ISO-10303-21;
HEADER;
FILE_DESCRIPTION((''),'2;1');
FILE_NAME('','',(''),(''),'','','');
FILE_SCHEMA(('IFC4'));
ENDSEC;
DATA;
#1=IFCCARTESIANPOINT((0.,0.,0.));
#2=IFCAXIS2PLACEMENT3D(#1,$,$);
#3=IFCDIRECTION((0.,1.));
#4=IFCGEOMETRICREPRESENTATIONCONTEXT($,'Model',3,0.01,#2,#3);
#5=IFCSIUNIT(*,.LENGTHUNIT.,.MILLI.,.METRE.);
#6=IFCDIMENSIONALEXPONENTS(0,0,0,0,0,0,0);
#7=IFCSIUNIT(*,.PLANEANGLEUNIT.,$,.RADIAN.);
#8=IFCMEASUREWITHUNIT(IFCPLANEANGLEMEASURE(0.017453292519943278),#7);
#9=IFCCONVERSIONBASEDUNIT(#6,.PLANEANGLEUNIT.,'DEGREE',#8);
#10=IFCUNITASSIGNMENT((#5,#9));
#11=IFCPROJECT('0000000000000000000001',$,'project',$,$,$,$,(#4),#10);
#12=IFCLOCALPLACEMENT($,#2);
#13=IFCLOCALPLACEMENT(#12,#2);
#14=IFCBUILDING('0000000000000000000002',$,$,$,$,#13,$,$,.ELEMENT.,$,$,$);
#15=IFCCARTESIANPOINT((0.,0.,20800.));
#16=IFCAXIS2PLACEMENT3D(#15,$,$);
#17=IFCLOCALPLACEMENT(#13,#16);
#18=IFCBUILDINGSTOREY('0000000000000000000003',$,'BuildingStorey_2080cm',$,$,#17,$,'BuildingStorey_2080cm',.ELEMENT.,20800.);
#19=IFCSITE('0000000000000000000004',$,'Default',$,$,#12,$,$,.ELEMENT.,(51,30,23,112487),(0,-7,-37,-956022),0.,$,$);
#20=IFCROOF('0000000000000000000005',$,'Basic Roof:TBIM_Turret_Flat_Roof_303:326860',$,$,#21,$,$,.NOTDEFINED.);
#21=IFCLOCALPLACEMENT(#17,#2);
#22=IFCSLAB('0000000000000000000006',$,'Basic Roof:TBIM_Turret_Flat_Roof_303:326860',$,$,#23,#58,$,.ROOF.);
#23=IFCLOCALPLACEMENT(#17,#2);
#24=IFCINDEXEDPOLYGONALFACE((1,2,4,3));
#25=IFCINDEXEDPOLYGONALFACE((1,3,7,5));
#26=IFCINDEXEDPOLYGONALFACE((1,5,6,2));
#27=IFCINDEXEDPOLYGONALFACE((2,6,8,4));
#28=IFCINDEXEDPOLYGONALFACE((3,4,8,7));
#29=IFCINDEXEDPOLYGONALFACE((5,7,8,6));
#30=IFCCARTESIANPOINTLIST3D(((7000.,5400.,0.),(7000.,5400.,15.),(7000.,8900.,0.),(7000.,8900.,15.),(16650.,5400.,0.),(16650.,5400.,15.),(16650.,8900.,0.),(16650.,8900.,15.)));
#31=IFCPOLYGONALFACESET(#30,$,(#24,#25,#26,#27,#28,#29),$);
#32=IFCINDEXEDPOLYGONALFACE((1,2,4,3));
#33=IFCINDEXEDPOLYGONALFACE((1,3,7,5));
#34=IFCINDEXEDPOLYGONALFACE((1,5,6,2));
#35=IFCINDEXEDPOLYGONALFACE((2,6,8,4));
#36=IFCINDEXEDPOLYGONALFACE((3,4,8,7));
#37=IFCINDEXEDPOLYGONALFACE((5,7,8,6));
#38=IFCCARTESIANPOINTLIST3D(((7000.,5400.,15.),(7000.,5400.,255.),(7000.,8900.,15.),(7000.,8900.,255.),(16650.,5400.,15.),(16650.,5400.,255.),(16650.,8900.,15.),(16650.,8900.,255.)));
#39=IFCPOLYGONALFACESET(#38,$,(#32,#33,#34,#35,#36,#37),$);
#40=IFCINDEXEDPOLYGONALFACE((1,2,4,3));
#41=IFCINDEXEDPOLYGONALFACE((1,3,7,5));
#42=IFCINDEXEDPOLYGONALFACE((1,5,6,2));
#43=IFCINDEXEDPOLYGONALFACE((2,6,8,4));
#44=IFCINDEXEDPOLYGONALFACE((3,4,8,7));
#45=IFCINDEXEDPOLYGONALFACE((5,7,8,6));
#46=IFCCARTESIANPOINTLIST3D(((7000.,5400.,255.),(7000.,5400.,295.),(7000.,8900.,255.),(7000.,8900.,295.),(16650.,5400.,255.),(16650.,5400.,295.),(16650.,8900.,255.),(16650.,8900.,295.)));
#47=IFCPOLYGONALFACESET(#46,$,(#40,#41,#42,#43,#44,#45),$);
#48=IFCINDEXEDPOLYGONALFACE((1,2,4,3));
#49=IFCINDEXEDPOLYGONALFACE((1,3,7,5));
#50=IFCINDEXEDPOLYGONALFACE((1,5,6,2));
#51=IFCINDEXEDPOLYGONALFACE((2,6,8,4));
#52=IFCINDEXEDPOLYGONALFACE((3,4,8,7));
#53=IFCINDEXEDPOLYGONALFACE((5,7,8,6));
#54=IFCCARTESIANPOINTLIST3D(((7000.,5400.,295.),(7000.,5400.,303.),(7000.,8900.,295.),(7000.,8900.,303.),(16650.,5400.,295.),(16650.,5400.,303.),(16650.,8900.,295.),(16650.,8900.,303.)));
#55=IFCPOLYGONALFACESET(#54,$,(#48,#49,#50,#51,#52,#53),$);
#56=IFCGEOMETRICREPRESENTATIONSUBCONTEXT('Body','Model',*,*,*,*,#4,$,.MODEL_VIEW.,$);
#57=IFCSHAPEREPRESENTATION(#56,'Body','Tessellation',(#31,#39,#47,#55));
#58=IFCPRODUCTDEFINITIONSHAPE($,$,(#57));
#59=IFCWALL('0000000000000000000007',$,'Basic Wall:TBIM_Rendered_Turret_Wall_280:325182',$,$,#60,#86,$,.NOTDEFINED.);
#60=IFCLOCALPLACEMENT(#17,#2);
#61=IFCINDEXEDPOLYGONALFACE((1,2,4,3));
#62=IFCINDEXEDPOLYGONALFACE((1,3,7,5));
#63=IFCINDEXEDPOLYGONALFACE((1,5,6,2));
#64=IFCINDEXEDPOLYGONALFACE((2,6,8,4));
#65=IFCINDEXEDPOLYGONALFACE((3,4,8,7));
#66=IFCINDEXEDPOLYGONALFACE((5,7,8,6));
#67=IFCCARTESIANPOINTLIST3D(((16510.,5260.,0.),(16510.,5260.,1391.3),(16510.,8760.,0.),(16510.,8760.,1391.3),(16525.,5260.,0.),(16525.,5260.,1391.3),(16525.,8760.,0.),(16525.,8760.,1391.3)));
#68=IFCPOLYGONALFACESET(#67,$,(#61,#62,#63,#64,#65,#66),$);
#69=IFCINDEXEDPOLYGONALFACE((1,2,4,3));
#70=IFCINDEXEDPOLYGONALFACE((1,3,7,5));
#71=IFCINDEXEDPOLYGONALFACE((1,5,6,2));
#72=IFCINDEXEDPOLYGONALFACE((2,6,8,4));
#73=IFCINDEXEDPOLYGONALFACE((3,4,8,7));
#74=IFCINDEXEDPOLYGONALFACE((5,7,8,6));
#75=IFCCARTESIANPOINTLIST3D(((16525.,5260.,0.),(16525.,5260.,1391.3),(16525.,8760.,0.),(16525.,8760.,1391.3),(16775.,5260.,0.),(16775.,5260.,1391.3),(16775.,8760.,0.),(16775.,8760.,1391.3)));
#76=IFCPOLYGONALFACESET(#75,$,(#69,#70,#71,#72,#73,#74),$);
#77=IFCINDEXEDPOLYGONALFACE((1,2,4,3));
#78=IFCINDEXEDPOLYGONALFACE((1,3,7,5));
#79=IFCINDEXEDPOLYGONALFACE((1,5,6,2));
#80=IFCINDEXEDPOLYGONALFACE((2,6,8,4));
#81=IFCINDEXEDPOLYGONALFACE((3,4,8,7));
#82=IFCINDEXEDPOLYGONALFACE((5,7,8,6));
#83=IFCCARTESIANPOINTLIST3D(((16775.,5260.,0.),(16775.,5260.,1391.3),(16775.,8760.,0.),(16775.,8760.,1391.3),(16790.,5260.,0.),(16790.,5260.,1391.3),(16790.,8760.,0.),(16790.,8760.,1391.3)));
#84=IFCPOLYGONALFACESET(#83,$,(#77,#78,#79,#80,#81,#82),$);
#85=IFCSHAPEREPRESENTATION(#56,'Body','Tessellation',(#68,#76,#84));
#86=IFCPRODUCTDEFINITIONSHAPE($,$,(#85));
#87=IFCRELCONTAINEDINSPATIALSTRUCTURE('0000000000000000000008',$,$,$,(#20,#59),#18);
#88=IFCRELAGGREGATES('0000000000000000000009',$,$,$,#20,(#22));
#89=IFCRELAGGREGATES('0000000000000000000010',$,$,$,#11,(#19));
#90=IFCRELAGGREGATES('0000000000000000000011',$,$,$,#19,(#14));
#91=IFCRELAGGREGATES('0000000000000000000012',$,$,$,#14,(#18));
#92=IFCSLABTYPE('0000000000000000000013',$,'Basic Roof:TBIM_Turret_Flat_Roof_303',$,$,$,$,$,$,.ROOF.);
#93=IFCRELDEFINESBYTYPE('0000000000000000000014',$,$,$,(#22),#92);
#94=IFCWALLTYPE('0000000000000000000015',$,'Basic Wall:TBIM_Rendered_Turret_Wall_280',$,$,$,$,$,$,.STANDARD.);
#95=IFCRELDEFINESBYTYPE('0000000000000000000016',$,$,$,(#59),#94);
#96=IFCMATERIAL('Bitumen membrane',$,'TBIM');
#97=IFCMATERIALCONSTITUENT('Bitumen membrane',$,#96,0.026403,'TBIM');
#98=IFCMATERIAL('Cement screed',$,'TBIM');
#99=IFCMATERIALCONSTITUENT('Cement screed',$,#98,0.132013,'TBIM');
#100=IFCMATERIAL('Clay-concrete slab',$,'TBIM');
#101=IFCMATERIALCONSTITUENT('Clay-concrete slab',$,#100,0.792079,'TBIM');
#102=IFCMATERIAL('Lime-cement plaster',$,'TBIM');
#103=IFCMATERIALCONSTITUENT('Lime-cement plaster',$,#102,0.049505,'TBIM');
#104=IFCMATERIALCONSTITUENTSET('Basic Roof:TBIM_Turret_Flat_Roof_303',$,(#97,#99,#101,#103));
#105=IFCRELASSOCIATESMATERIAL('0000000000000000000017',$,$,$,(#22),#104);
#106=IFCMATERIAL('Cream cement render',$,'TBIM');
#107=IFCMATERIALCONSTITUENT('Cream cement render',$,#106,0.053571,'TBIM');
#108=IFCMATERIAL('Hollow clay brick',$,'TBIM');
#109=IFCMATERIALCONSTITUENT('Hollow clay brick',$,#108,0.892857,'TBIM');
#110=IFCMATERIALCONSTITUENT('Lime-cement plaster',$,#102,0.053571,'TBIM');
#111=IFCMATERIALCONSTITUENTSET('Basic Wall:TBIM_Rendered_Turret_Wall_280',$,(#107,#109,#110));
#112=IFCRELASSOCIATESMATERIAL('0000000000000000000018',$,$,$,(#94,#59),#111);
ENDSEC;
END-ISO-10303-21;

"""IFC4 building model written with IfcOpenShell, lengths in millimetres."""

from ifc_helpers import new_model, entity, si_unit, converted_unit, direction, frame, origin, place, context, subcontext, project, spatial, indexed_curve, outline, extrude, material, constituent, constituent_set, type_object, element, aggregate, save


model = new_model("IFC4")

# Units and contexts
model_context = context("Model", 3, precision=0.01, world=origin(), true_north=direction((0.0, 1.0)))
body_context = subcontext(model_context, "Body", "Model", "MODEL_VIEW")
ifc_project = project(units=[si_unit("LENGTHUNIT", "METRE", prefix="MILLI"), converted_unit("PLANEANGLEUNIT", "DEGREE", entity("IfcPlaneAngleMeasure", 0.017453292519943278), si_unit("PLANEANGLEUNIT", "RADIAN"), dimensions=[0, 0, 0, 0, 0, 0, 0])], contexts=[model_context])

# Site, building, storey
site_placement = place(None, origin())
site = spatial("IfcSite", under=ifc_project, at=site_placement, Name="Default", CompositionType="ELEMENT", RefLatitude=(51, 30, 23, 112487), RefLongitude=(0, -7, -37, -956022), RefElevation=0.0)
building_placement = place(site_placement, origin())
building = spatial("IfcBuilding", under=site, at=building_placement, CompositionType="ELEMENT")
storey_placement = place(building_placement, frame((0.0, 0.0, 20800.0)))
storey = spatial("IfcBuildingStorey", under=building, at=storey_placement, Name="BuildingStorey_2080cm", LongName="BuildingStorey_2080cm", CompositionType="ELEMENT", Elevation=20800.0)

# Roof, slab
roof_placement = place(storey_placement, frame((7000.0, 5400.0, 0.0)))
roof = element("IfcRoof", 1, at=roof_placement, inside=storey, Name="Basic Roof:TBIM_Turret_Flat_Roof_303:326860", PredefinedType="NOTDEFINED")
ifc_material_1 = material(Name="Bitumen membrane", Category="TBIM")
ifc_constituent_1 = constituent(ifc_material_1, Name="Bitumen membrane", Category="TBIM", fraction=0.026403)
ifc_material_2 = material(Name="Cement screed", Category="TBIM")
ifc_constituent_2 = constituent(ifc_material_2, Name="Cement screed", Category="TBIM", fraction=0.132013)
ifc_material_3 = material(Name="Clay-concrete slab", Category="TBIM")
ifc_constituent_3 = constituent(ifc_material_3, Name="Clay-concrete slab", Category="TBIM", fraction=0.792079)
ifc_material_4 = material(Name="Lime-cement plaster", Category="TBIM")
ifc_constituent_4 = constituent(ifc_material_4, Name="Lime-cement plaster", Category="TBIM", fraction=0.049505)
ifc_constituent_set_1 = constituent_set(constituents=[ifc_constituent_1, ifc_constituent_2, ifc_constituent_3, ifc_constituent_4], Name="Basic Roof:TBIM_Turret_Flat_Roof_303")
slab_type = type_object("IfcSlabType", Name="Basic Roof:TBIM_Turret_Flat_Roof_303", PredefinedType="ROOF")
slab_placement = place(roof_placement, origin())
slab = element("IfcSlab", 2, at=slab_placement, type_object=slab_type, material=ifc_constituent_set_1, Name="Basic Roof:TBIM_Turret_Flat_Roof_303:326860", PredefinedType="ROOF", context=body_context, shape_type="SweptSolid", body=[
    extrude(outline(indexed_curve([(-4825.0, 1750.0), (-4825.0, -1750.0), (4825.0, -1750.0), (4825.0, 1750.0), (-4825.0, 1750.0)], self_intersect=False)), frame((4825.0, 1750.0, 0.0)), (0.0, 0.0, 1.0), 15.0),
    extrude(outline(indexed_curve([(-4825.0, 1750.0), (-4825.0, -1750.0), (4825.0, -1750.0), (4825.0, 1750.0), (-4825.0, 1750.0)], self_intersect=False)), frame((4825.0, 1750.0, 15.0)), (0.0, 0.0, 1.0), 240.0),
    extrude(outline(indexed_curve([(-4825.0, 1750.0), (-4825.0, -1750.0), (4825.0, -1750.0), (4825.0, 1750.0), (-4825.0, 1750.0)], self_intersect=False)), frame((4825.0, 1750.0, 255.0)), (0.0, 0.0, 1.0), 40.0),
    extrude(outline(indexed_curve([(-4825.0, 1750.0), (-4825.0, -1750.0), (4825.0, -1750.0), (4825.0, 1750.0), (-4825.0, 1750.0)], self_intersect=False)), frame((4825.0, 1750.0, 295.0)), (0.0, 0.0, 1.0), 8.0),
])
aggregate(roof, [slab])

# Wall
ifc_material_5 = material(Name="Cream cement render", Category="TBIM")
ifc_constituent_5 = constituent(ifc_material_5, Name="Cream cement render", Category="TBIM", fraction=0.053571)
ifc_material_6 = material(Name="Hollow clay brick", Category="TBIM")
ifc_constituent_6 = constituent(ifc_material_6, Name="Hollow clay brick", Category="TBIM", fraction=0.892857)
ifc_constituent_7 = constituent(ifc_material_4, Name="Lime-cement plaster", Category="TBIM", fraction=0.053571)
ifc_constituent_set_2 = constituent_set(constituents=[ifc_constituent_5, ifc_constituent_6, ifc_constituent_7], Name="Basic Wall:TBIM_Rendered_Turret_Wall_280")
wall_type = type_object("IfcWallType", Name="Basic Wall:TBIM_Rendered_Turret_Wall_280", PredefinedType="STANDARD", material=ifc_constituent_set_2)
wall_1_placement = place(storey_placement, frame((16650.0, 5260.0, 0.0), z_axis=(0.0, 0.0, 1.0), x_axis=(0.0, 1.0, 0.0)))
element("IfcWall", 3, at=wall_1_placement, inside=storey, type_object=wall_type, material=ifc_constituent_set_2, Name="Basic Wall:TBIM_Rendered_Turret_Wall_280:325182", PredefinedType="NOTDEFINED", context=body_context, shape_type="SweptSolid", body=[
    extrude(outline(indexed_curve([(-7.5, -1750.0), (7.5, -1750.0), (7.5, 1750.0), (-7.5, 1750.0), (-7.5, -1750.0)], self_intersect=False)), frame((1750.0, 132.5, 0.0), z_axis=(0.0, 0.0, 1.0), x_axis=(0.0, -1.0, 0.0)), (0.0, 0.0, 1.0), 1391.3),
    extrude(outline(indexed_curve([(-1750.0, -125.0), (1750.0, -125.0), (1750.0, 125.0), (-1750.0, 125.0), (-1750.0, -125.0)], self_intersect=False)), frame((1750.0, 0.0, 0.0)), (0.0, 0.0, 1.0), 1391.3),
    extrude(outline(indexed_curve([(-7.5, -1750.0), (7.5, -1750.0), (7.5, 1750.0), (-7.5, 1750.0), (-7.5, -1750.0)], self_intersect=False)), frame((1750.0, -132.5, 0.0), z_axis=(0.0, 0.0, 1.0), x_axis=(0.0, 1.0, 0.0)), (0.0, 0.0, 1.0), 1391.3),
])

save(model, "model.ifc")
